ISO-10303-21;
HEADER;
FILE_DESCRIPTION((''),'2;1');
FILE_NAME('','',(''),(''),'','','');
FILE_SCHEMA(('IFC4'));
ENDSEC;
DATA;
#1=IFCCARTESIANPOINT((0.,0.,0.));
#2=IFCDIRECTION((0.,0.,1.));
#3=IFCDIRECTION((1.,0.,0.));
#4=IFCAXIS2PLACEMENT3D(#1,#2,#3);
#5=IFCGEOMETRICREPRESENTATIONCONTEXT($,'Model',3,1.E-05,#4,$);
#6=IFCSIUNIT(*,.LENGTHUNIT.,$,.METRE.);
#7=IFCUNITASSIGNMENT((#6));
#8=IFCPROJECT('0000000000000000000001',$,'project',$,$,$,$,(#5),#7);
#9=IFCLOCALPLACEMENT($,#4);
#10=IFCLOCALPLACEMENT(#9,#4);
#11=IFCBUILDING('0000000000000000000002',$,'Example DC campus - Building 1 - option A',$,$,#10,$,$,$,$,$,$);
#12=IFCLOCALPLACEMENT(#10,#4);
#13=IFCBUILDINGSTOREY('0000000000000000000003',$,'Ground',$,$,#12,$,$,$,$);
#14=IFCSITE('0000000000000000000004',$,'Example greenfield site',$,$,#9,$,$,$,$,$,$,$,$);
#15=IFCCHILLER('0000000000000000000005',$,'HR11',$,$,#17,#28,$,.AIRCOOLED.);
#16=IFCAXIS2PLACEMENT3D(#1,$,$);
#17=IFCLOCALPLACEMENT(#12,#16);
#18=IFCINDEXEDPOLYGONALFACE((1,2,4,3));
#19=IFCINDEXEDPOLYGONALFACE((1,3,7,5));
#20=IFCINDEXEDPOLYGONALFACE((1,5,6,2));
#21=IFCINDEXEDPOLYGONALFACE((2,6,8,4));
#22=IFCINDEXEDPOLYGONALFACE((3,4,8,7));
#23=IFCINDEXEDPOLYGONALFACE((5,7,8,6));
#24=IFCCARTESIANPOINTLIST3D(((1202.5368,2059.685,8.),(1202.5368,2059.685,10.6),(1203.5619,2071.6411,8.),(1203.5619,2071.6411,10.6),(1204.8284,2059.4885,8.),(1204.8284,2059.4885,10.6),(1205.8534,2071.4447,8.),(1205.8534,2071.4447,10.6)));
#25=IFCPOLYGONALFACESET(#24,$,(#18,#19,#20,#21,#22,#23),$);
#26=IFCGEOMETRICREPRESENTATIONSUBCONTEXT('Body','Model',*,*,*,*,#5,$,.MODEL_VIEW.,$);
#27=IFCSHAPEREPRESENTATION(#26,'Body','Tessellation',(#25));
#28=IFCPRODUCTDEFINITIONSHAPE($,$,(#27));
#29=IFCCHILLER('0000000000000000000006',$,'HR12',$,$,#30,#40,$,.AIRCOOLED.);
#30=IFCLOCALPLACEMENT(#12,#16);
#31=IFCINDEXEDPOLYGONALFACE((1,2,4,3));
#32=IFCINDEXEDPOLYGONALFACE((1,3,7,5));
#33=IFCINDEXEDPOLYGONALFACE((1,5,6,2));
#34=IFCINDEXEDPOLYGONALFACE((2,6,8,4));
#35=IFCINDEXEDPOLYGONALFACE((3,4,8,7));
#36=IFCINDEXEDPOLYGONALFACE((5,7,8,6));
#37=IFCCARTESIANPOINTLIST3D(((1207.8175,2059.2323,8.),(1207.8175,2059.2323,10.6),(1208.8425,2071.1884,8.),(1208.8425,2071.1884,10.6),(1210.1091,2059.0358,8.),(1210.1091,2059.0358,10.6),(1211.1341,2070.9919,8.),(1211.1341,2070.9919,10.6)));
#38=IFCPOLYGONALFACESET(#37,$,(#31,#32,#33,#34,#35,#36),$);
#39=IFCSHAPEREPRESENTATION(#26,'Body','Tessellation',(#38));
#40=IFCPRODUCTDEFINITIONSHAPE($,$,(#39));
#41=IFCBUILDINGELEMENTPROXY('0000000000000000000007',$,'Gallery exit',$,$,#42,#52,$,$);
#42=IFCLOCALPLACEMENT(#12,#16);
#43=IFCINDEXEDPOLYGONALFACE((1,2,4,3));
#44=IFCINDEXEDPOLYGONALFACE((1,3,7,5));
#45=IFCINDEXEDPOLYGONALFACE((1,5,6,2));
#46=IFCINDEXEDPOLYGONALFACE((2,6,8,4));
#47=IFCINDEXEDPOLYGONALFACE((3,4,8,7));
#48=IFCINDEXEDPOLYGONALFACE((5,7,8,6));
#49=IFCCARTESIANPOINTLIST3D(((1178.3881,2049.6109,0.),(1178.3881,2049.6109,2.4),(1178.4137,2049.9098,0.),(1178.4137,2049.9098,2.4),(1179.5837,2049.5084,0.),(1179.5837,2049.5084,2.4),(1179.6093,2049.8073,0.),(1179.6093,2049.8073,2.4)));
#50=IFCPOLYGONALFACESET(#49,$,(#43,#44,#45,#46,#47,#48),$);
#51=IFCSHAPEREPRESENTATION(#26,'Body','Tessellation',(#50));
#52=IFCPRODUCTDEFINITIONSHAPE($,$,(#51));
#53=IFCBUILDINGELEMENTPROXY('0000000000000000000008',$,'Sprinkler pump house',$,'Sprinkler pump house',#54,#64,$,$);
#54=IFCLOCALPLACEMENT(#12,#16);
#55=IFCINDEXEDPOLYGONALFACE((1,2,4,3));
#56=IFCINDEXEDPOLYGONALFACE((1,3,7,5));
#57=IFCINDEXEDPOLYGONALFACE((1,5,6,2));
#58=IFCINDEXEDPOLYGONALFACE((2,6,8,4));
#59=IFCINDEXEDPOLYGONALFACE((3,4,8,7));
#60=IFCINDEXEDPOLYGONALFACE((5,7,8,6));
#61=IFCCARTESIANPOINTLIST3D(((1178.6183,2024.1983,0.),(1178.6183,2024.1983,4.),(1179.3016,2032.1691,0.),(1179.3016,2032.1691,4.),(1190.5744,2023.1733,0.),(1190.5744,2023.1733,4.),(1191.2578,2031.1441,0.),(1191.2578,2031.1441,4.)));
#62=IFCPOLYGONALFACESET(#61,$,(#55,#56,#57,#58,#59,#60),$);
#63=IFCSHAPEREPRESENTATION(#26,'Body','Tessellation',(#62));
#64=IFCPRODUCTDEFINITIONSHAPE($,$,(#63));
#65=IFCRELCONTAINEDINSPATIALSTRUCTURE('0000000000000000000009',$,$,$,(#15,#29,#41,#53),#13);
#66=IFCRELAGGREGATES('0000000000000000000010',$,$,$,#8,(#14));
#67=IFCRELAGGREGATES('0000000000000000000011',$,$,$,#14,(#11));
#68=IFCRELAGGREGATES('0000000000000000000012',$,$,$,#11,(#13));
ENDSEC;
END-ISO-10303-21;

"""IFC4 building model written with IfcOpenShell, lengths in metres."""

from ifc_helpers import new_model, si_unit, frame, origin_with_axes, place, context, subcontext, project, spatial, line, indexed_curve, outline, extrude, element, save


model = new_model("IFC4")

# Units and contexts
model_context = context("Model", 3, precision=1e-05, world=origin_with_axes())
body_context = subcontext(model_context, "Body", "Model", "MODEL_VIEW")
ifc_project = project(units=[si_unit("LENGTHUNIT", "METRE")], contexts=[model_context])

# Site, building, storey
site_placement = place(None, origin_with_axes())
site = spatial("IfcSite", under=ifc_project, at=site_placement, Name="Example greenfield site")
building_placement = place(site_placement, origin_with_axes())
building = spatial("IfcBuilding", under=site, at=building_placement, Name="Example DC campus - Building 1 - option A")
storey_placement = place(building_placement, origin_with_axes())
storey = spatial("IfcBuildingStorey", under=building, at=storey_placement, Name="Ground")

# Chillers
for number, where, z_axis, x_axis, name in (
    (1, (1202.5368, 2059.685, 8.0), (0.0, 0.0, 1.0), (0.996345, -0.085417, 0.0), "HR11"),
    (2, (1207.8175, 2059.2323, 8.0), (0.0, 0.0, 1.0), (0.996345, -0.085417, 0.0), "HR12"),
):
    element("IfcChiller", number, at=place(storey_placement, frame(where, z_axis=z_axis, x_axis=x_axis)), inside=storey, Name=name, PredefinedType="AIRCOOLED", context=body_context, shape_type="SweptSolid", body=[
        extrude(outline(indexed_curve([(0.0, 0.0), (2.3, 0.0), (2.3, 12.0), (0.0, 12.0)], segments=[line(1, 2, 3, 4, 1)])), origin_with_axes(), (0.0, 0.0, 1.0), 2.6),
    ])

# Building element proxies
proxy_1_placement = place(storey_placement, frame((1178.3881, 2049.6109, 0.0), z_axis=(0.0, 0.0, 1.0), x_axis=(0.996345, -0.085417, 0.0)))
element("IfcBuildingElementProxy", 3, at=proxy_1_placement, inside=storey, Name="Gallery exit", context=body_context, shape_type="SweptSolid", body=[
    extrude(outline(indexed_curve([(0.0, 0.0), (1.2, 0.0), (1.2, 0.3), (0.0, 0.3)], segments=[line(1, 2, 3, 4, 1)])), origin_with_axes(), (0.0, 0.0, 1.0), 2.4),
])
proxy_2_placement = place(storey_placement, frame((1178.6183, 2024.1983, 0.0), z_axis=(0.0, 0.0, 1.0), x_axis=(0.996345, -0.085417, 0.0)))
element("IfcBuildingElementProxy", 4, at=proxy_2_placement, inside=storey, Name="Sprinkler pump house", ObjectType="Sprinkler pump house", context=body_context, shape_type="SweptSolid", body=[
    extrude(outline(indexed_curve([(0.0, 0.0), (12.0, 0.0), (12.0, 8.0), (0.0, 8.0)], segments=[line(1, 2, 3, 4, 1)])), origin_with_axes(), (0.0, 0.0, 1.0), 4.0),
])

save(model, "model.ifc")
